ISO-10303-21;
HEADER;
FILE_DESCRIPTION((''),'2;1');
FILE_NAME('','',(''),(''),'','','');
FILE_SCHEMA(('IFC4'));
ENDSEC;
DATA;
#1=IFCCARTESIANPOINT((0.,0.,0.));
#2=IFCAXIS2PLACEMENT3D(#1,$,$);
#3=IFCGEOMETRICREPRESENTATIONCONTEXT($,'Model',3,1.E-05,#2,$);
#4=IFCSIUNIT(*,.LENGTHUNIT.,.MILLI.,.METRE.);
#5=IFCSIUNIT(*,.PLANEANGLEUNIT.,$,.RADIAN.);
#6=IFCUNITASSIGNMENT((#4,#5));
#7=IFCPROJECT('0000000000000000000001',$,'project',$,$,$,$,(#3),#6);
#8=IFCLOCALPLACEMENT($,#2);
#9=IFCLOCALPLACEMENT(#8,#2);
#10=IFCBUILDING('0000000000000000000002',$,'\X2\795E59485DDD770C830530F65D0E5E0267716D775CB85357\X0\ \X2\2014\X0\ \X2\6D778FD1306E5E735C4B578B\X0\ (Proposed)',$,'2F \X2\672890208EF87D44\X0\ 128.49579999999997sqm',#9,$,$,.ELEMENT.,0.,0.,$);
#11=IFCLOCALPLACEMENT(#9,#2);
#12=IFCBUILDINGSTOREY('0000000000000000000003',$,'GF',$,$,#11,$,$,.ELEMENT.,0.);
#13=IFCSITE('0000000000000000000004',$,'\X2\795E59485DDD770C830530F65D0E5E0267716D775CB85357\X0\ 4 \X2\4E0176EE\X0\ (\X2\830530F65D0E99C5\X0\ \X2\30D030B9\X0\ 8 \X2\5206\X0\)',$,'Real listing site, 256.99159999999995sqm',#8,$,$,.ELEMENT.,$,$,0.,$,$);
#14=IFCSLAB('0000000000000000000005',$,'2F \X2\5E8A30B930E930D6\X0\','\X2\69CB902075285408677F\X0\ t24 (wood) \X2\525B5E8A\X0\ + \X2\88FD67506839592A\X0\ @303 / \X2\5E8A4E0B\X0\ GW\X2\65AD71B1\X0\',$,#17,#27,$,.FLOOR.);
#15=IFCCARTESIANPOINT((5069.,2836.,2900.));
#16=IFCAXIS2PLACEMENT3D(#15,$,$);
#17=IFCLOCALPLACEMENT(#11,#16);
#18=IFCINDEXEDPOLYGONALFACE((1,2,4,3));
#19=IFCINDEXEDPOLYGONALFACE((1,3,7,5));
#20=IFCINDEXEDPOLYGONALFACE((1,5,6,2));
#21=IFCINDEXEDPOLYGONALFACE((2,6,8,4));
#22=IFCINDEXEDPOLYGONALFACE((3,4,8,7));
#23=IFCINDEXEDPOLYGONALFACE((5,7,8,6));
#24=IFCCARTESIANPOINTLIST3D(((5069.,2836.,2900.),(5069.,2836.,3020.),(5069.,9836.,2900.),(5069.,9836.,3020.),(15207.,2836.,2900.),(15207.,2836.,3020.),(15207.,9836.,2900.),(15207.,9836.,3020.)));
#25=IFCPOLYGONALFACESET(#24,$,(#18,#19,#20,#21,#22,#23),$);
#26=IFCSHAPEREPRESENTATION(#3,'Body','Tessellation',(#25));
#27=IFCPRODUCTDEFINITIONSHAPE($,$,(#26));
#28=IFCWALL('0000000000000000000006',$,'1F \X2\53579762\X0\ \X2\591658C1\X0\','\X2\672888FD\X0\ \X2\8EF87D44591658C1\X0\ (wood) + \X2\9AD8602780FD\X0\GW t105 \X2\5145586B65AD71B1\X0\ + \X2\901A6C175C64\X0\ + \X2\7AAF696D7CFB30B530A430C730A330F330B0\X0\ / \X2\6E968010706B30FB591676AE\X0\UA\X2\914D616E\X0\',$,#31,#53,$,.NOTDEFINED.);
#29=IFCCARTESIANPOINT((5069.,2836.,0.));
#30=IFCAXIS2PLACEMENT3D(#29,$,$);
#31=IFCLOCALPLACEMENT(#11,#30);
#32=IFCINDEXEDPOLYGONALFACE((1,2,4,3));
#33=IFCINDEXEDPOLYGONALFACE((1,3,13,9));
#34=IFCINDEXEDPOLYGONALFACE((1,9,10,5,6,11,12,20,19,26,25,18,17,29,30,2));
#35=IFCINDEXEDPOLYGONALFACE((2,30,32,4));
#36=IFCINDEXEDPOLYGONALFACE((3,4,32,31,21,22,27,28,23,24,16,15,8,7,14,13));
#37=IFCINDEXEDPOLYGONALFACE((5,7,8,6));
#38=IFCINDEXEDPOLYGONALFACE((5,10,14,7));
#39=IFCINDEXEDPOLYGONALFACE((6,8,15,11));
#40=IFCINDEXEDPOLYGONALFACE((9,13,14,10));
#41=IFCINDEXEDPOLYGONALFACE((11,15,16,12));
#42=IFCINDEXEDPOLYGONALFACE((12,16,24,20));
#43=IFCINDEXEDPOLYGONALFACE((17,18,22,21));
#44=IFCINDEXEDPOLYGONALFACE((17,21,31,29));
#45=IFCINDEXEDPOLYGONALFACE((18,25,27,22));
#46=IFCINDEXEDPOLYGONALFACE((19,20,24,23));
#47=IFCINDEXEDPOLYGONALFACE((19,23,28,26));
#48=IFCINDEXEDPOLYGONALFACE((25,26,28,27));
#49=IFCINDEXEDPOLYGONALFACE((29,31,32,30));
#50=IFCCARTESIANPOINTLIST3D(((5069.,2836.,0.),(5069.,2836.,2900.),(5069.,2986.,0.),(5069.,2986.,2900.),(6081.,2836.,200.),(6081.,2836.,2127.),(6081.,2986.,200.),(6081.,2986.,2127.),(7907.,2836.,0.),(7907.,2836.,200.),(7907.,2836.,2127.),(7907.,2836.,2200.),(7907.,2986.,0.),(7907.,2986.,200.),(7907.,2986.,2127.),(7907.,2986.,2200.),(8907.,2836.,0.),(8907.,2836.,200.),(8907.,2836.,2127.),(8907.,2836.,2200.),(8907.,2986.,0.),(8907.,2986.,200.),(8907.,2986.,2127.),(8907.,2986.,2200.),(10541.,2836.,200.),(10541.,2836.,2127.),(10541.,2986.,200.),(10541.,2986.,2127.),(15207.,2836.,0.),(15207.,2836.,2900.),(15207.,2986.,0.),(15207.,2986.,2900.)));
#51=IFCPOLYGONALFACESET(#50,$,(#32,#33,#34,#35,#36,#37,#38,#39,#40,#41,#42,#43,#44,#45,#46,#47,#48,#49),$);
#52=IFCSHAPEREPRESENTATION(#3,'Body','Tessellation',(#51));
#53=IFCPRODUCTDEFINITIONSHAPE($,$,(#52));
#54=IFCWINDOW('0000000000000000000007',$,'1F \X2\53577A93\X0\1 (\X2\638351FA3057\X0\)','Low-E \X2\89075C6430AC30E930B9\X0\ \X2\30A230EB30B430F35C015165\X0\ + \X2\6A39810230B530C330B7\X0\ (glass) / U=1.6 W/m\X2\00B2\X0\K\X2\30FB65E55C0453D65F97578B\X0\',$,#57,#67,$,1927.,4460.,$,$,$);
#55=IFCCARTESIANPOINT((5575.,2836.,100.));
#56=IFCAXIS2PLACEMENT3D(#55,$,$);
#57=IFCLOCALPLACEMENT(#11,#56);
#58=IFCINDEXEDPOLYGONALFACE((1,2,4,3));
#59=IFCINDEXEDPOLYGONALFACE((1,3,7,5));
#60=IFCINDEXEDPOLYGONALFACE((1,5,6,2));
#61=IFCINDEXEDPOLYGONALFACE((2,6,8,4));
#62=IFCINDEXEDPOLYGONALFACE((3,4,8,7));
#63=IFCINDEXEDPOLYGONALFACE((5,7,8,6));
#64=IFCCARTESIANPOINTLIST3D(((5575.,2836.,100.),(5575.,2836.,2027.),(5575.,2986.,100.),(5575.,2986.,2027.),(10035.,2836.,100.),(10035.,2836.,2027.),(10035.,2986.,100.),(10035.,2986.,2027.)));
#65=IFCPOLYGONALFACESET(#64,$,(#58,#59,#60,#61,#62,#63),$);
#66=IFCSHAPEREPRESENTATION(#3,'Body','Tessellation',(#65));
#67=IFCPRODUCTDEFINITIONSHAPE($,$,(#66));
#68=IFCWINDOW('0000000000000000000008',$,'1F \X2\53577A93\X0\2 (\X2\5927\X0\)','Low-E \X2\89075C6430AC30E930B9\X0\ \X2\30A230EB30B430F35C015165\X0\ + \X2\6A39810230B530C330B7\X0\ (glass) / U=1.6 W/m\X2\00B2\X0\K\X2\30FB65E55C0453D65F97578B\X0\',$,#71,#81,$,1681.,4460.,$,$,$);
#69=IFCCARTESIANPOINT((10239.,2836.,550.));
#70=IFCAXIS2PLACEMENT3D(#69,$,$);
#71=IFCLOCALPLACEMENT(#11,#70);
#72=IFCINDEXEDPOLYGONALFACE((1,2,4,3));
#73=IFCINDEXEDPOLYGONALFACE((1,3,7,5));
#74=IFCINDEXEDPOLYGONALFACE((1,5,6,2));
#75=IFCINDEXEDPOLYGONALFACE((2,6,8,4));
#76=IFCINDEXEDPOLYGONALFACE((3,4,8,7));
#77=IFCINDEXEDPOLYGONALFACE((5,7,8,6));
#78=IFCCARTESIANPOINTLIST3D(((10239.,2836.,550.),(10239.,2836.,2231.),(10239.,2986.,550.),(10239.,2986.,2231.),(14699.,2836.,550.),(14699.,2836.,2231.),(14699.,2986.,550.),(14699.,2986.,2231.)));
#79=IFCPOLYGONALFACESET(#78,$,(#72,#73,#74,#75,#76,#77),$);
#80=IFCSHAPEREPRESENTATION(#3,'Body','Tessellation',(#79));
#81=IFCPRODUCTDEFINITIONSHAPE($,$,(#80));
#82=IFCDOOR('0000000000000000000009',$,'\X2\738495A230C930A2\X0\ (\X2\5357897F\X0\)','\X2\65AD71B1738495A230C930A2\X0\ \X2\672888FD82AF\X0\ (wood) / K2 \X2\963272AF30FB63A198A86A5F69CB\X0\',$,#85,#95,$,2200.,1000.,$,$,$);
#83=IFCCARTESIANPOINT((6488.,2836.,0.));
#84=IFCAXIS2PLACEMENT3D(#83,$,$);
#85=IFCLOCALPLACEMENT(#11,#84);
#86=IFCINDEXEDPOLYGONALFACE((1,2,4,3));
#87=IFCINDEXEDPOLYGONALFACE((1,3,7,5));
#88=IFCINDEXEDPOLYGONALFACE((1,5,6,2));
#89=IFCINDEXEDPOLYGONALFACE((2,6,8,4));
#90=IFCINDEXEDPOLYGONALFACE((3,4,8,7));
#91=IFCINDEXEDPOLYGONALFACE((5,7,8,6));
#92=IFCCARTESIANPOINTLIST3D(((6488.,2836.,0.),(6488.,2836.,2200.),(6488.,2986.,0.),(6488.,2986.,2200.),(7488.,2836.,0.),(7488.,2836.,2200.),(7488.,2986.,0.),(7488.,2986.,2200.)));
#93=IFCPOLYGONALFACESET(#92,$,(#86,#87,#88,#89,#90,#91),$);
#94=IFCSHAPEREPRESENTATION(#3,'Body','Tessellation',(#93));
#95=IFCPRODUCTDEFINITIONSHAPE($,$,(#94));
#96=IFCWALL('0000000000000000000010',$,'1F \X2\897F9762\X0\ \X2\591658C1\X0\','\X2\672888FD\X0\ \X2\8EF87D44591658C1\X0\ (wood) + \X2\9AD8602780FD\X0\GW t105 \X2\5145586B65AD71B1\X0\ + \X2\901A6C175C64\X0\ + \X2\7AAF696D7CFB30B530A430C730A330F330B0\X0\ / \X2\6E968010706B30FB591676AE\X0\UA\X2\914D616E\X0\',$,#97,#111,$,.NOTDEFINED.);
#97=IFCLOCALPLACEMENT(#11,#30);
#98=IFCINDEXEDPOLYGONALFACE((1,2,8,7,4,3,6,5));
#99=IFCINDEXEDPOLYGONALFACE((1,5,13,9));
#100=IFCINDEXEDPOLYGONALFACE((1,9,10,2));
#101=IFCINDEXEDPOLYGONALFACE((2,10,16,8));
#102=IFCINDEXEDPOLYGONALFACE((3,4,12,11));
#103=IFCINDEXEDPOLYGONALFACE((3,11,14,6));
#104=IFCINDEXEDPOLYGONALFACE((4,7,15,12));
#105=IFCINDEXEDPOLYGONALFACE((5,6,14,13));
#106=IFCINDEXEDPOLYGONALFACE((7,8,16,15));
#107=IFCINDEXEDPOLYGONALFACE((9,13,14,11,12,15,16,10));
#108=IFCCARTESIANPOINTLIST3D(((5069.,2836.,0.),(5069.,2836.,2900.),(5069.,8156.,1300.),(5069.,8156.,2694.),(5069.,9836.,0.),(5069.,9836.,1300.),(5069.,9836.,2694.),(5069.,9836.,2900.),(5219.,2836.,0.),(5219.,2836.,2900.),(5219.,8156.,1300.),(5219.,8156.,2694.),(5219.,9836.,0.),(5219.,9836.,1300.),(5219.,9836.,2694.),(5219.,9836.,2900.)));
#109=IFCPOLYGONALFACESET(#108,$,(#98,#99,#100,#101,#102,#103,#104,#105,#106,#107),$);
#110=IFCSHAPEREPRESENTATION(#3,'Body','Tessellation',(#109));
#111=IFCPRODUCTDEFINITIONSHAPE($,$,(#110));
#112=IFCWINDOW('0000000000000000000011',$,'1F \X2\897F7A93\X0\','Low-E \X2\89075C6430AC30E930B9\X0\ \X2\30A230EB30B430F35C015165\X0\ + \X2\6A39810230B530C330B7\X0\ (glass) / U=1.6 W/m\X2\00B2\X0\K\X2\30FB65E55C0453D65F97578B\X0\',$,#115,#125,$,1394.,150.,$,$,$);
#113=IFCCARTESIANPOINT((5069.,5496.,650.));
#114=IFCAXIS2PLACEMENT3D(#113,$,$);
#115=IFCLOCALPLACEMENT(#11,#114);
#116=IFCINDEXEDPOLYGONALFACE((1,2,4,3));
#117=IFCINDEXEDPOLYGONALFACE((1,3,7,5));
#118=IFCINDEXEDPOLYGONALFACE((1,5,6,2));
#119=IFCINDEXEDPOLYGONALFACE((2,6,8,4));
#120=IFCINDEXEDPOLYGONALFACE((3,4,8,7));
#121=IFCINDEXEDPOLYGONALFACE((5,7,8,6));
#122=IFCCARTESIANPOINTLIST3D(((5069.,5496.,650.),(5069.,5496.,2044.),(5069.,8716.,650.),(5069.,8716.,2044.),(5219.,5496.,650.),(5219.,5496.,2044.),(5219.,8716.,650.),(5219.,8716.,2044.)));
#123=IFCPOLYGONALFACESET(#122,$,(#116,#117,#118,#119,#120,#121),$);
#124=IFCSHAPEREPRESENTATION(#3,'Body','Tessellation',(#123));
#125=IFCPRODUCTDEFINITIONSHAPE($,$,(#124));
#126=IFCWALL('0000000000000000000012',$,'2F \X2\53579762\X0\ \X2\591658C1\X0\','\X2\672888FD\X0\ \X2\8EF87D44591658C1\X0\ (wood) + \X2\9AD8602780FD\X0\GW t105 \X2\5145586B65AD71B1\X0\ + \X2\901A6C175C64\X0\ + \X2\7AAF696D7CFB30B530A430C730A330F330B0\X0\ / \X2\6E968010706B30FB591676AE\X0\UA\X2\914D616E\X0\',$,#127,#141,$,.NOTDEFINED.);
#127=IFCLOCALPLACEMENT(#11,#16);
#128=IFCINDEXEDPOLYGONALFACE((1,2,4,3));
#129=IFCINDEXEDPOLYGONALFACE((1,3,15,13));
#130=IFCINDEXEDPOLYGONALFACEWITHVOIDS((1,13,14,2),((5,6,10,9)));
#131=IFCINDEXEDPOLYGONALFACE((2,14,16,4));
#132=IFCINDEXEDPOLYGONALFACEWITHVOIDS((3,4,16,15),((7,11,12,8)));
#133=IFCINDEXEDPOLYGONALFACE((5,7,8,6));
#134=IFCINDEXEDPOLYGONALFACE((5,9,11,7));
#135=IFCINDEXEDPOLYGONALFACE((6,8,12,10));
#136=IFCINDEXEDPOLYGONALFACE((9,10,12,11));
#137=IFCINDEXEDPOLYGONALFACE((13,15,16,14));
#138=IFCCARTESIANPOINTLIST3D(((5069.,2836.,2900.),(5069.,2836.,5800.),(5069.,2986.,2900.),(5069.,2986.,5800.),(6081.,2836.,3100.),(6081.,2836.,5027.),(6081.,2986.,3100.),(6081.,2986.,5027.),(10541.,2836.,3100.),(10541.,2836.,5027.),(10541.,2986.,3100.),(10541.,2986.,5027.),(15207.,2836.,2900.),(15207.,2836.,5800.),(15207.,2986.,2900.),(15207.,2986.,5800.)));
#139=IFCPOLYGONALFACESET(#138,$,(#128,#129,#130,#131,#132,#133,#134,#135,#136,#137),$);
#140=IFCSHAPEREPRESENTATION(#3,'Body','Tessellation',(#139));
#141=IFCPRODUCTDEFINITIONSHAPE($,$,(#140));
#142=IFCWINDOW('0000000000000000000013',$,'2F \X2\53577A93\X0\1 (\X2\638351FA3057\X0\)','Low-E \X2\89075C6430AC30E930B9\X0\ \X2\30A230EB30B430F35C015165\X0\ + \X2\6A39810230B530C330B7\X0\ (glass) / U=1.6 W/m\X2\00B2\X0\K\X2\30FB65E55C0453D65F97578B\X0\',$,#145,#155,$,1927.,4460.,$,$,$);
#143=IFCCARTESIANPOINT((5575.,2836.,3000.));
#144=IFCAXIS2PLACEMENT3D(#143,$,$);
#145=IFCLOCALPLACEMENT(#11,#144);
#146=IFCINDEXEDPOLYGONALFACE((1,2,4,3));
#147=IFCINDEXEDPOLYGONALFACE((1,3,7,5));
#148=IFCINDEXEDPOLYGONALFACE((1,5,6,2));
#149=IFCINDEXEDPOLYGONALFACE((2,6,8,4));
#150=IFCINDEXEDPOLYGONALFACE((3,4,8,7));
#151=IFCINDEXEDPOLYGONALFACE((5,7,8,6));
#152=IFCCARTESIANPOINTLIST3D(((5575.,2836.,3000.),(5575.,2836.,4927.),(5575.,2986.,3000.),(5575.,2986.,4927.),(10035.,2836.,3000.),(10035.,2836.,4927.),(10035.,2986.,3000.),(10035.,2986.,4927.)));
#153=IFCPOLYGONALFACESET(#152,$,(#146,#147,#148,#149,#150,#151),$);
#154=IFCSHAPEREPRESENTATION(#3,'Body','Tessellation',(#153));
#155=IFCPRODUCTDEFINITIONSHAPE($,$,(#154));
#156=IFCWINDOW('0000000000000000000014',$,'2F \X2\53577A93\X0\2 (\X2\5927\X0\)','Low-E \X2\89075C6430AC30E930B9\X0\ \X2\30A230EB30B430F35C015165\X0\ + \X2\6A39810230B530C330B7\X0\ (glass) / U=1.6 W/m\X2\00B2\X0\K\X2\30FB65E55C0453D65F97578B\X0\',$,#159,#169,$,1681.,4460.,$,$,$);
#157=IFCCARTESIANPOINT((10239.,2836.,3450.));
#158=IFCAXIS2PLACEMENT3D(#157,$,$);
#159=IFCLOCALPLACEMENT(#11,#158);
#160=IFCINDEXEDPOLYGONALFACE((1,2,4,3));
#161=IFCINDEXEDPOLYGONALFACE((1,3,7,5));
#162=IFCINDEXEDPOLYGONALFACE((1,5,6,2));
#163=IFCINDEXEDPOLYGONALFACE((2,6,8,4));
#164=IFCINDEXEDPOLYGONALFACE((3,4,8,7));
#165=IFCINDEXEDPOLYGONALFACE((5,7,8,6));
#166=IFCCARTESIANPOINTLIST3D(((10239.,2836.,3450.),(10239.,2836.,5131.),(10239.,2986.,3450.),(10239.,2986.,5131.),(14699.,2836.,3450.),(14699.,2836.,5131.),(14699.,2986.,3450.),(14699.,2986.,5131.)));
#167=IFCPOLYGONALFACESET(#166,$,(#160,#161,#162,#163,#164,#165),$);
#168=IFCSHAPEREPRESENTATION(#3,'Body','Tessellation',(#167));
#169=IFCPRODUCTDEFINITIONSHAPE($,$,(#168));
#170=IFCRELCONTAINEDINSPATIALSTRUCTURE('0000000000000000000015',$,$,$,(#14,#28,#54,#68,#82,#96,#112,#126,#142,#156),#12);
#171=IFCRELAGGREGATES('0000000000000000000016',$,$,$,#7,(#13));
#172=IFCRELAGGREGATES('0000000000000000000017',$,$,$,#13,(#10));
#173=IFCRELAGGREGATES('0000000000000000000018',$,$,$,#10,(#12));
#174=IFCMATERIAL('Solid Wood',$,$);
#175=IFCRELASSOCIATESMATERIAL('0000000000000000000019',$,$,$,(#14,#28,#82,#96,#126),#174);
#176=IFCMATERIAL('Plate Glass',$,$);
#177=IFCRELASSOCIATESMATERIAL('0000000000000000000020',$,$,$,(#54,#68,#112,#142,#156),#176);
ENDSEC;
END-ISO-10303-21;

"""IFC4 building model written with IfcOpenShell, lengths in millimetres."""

from ifc_helpers import new_model, si_unit, frame, frame_2d, origin, place, context, project, spatial, rectangle, extrude, material, element, fill, save


model = new_model("IFC4")

# Units and contexts
model_context = context("Model", 3, precision=1e-05, world=origin())
ifc_project = project(units=[si_unit("LENGTHUNIT", "METRE", prefix="MILLI"), si_unit("PLANEANGLEUNIT", "RADIAN")], contexts=[model_context])

# Site, building, storey
site_placement = place(None, origin())
site = spatial("IfcSite", under=ifc_project, at=site_placement, Name="神奈川県茅ヶ崎市東海岸南 4 丁目 (茅ヶ崎駅 バス 8 分)", ObjectType="Real listing site, 256.99159999999995sqm", CompositionType="ELEMENT", RefElevation=0.0)
building_placement = place(site_placement, origin())
building = spatial("IfcBuilding", under=site, at=building_placement, Name="神奈川県茅ヶ崎市東海岸南 — 海近の平屋型 (Proposed)", ObjectType="2F 木造軸組 128.49579999999997sqm", CompositionType="ELEMENT", ElevationOfRefHeight=0.0, ElevationOfTerrain=0.0)
storey_placement = place(building_placement, origin())
storey = spatial("IfcBuildingStorey", under=building, at=storey_placement, Name="GF", CompositionType="ELEMENT", Elevation=0.0)

# Slab
ifc_material_1 = material(Name="Solid Wood")
slab_1_placement = place(storey_placement, frame((5069.0, 2836.0, 2900.0)))
element("IfcSlab", 1, at=slab_1_placement, inside=storey, material=ifc_material_1, Name="2F 床スラブ", Description="構造用合板 t24 (wood) 剛床 + 製材根太 @303 / 床下 GW断熱", PredefinedType="FLOOR", context=model_context, shape_type="SweptSolid", body=[
    extrude(rectangle(XDim=10138.0, YDim=7000.0, at=frame_2d((5069.0, 3500.0))), frame((5069.0, 2836.0, 2900.0)), (0.0, 0.0, 1.0), 120.0),
])

# Wall, openings, windows, door
wall_1_placement = place(storey_placement, frame((5069.0, 2836.0, 0.0)))
wall_1 = element("IfcWall", 2, at=wall_1_placement, inside=storey, material=ifc_material_1, Name="1F 南面 外壁", Description="木製 軸組外壁 (wood) + 高性能GW t105 充填断熱 + 通気層 + 窯業系サイディング / 準耐火・外皮UA配慮", PredefinedType="NOTDEFINED", context=model_context, shape_type="SweptSolid", body=[
    extrude(rectangle(XDim=10138.0, YDim=150.0, at=frame_2d((5069.0, 75.0))), frame((5069.0, 2836.0, 0.0)), (0.0, 0.0, 1.0), 2900.0),
])
opening_1_placement = place(storey_placement, frame((5575.0, 2836.0, 100.0)))
opening_1 = element("IfcOpeningElement", 3, at=opening_1_placement, cuts=wall_1, PredefinedType="NOTDEFINED", context=model_context, shape_type="SweptSolid", body=[
    extrude(rectangle(XDim=4460.0, YDim=150.0, at=frame_2d((2230.0, 75.0))), frame((5575.0, 2836.0, 100.0)), (0.0, 0.0, 1.0), 1927.0),
])
opening_2_placement = place(storey_placement, frame((10239.0, 2836.0, 550.0)))
opening_2 = element("IfcOpeningElement", 4, at=opening_2_placement, cuts=wall_1, PredefinedType="NOTDEFINED", context=model_context, shape_type="SweptSolid", body=[
    extrude(rectangle(XDim=4460.0, YDim=150.0, at=frame_2d((2230.0, 75.0))), frame((10239.0, 2836.0, 550.0)), (0.0, 0.0, 1.0), 1681.0),
])
opening_3_placement = place(storey_placement, frame((6488.0, 2836.0, 0.0)))
opening_3 = element("IfcOpeningElement", 5, at=opening_3_placement, cuts=wall_1, PredefinedType="NOTDEFINED", context=model_context, shape_type="SweptSolid", body=[
    extrude(rectangle(XDim=1000.0, YDim=150.0, at=frame_2d((500.0, 75.0))), frame((6488.0, 2836.0, 0.0)), (0.0, 0.0, 1.0), 2200.0),
])
ifc_material_2 = material(Name="Plate Glass")
window_1_placement = place(storey_placement, frame((5575.0, 2836.0, 100.0)))
window_1 = element("IfcWindow", 6, at=window_1_placement, inside=storey, material=ifc_material_2, Name="1F 南窓1 (掃出し)", Description="Low-E 複層ガラス アルゴン封入 + 樹脂サッシ (glass) / U=1.6 W/m²K・日射取得型", OverallHeight=1927.0, OverallWidth=4460.0, context=model_context, shape_type="SweptSolid", body=[
    extrude(rectangle(XDim=4460.0, YDim=150.0, at=frame_2d((2230.0, 75.0))), frame((5575.0, 2836.0, 100.0)), (0.0, 0.0, 1.0), 1927.0),
])
fill(opening_1, window_1)
window_2_placement = place(storey_placement, frame((10239.0, 2836.0, 550.0)))
window_2 = element("IfcWindow", 7, at=window_2_placement, inside=storey, material=ifc_material_2, Name="1F 南窓2 (大)", Description="Low-E 複層ガラス アルゴン封入 + 樹脂サッシ (glass) / U=1.6 W/m²K・日射取得型", OverallHeight=1681.0, OverallWidth=4460.0, context=model_context, shape_type="SweptSolid", body=[
    extrude(rectangle(XDim=4460.0, YDim=150.0, at=frame_2d((2230.0, 75.0))), frame((10239.0, 2836.0, 550.0)), (0.0, 0.0, 1.0), 1681.0),
])
fill(opening_2, window_2)
door_placement = place(storey_placement, frame((6488.0, 2836.0, 0.0)))
door = element("IfcDoor", 8, at=door_placement, inside=storey, material=ifc_material_1, Name="玄関ドア (南西)", Description="断熱玄関ドア 木製芯 (wood) / K2 防犯・採風機構", OverallHeight=2200.0, OverallWidth=1000.0, context=model_context, shape_type="SweptSolid", body=[
    extrude(rectangle(XDim=1000.0, YDim=150.0, at=frame_2d((500.0, 75.0))), frame((6488.0, 2836.0, 0.0)), (0.0, 0.0, 1.0), 2200.0),
])
fill(opening_3, door)

# Wall, opening, window
wall_2_placement = place(storey_placement, frame((5069.0, 2836.0, 0.0)))
wall_2 = element("IfcWall", 9, at=wall_2_placement, inside=storey, material=ifc_material_1, Name="1F 西面 外壁", Description="木製 軸組外壁 (wood) + 高性能GW t105 充填断熱 + 通気層 + 窯業系サイディング / 準耐火・外皮UA配慮", PredefinedType="NOTDEFINED", context=model_context, shape_type="SweptSolid", body=[
    extrude(rectangle(XDim=150.0, YDim=7000.0, at=frame_2d((75.0, 3500.0))), frame((5069.0, 2836.0, 0.0)), (0.0, 0.0, 1.0), 2900.0),
])
opening_4_placement = place(storey_placement, frame((5069.0, 5496.0, 650.0)))
opening_4 = element("IfcOpeningElement", 10, at=opening_4_placement, cuts=wall_2, PredefinedType="NOTDEFINED", context=model_context, shape_type="SweptSolid", body=[
    extrude(rectangle(XDim=150.0, YDim=3220.0, at=frame_2d((75.0, 1610.0))), frame((5069.0, 5496.0, 650.0)), (0.0, 0.0, 1.0), 1394.0),
])
window_3_placement = place(storey_placement, frame((5069.0, 5496.0, 650.0)))
window_3 = element("IfcWindow", 11, at=window_3_placement, inside=storey, material=ifc_material_2, Name="1F 西窓", Description="Low-E 複層ガラス アルゴン封入 + 樹脂サッシ (glass) / U=1.6 W/m²K・日射取得型", OverallHeight=1394.0, OverallWidth=150.0, context=model_context, shape_type="SweptSolid", body=[
    extrude(rectangle(XDim=150.0, YDim=3220.0, at=frame_2d((75.0, 1610.0))), frame((5069.0, 5496.0, 650.0)), (0.0, 0.0, 1.0), 1394.0),
])
fill(opening_4, window_3)

# Wall, openings, windows
wall_3_placement = place(storey_placement, frame((5069.0, 2836.0, 2900.0)))
wall_3 = element("IfcWall", 12, at=wall_3_placement, inside=storey, material=ifc_material_1, Name="2F 南面 外壁", Description="木製 軸組外壁 (wood) + 高性能GW t105 充填断熱 + 通気層 + 窯業系サイディング / 準耐火・外皮UA配慮", PredefinedType="NOTDEFINED", context=model_context, shape_type="SweptSolid", body=[
    extrude(rectangle(XDim=10138.0, YDim=150.0, at=frame_2d((5069.0, 75.0))), frame((5069.0, 2836.0, 2900.0)), (0.0, 0.0, 1.0), 2900.0),
])
opening_5_placement = place(storey_placement, frame((5575.0, 2836.0, 3000.0)))
opening_5 = element("IfcOpeningElement", 13, at=opening_5_placement, cuts=wall_3, PredefinedType="NOTDEFINED", context=model_context, shape_type="SweptSolid", body=[
    extrude(rectangle(XDim=4460.0, YDim=150.0, at=frame_2d((2230.0, 75.0))), frame((5575.0, 2836.0, 3000.0)), (0.0, 0.0, 1.0), 1927.0),
])
opening_6_placement = place(storey_placement, frame((10239.0, 2836.0, 3450.0)))
opening_6 = element("IfcOpeningElement", 14, at=opening_6_placement, cuts=wall_3, PredefinedType="NOTDEFINED", context=model_context, shape_type="SweptSolid", body=[
    extrude(rectangle(XDim=4460.0, YDim=150.0, at=frame_2d((2230.0, 75.0))), frame((10239.0, 2836.0, 3450.0)), (0.0, 0.0, 1.0), 1681.0),
])
window_4_placement = place(storey_placement, frame((5575.0, 2836.0, 3000.0)))
window_4 = element("IfcWindow", 15, at=window_4_placement, inside=storey, material=ifc_material_2, Name="2F 南窓1 (掃出し)", Description="Low-E 複層ガラス アルゴン封入 + 樹脂サッシ (glass) / U=1.6 W/m²K・日射取得型", OverallHeight=1927.0, OverallWidth=4460.0, context=model_context, shape_type="SweptSolid", body=[
    extrude(rectangle(XDim=4460.0, YDim=150.0, at=frame_2d((2230.0, 75.0))), frame((5575.0, 2836.0, 3000.0)), (0.0, 0.0, 1.0), 1927.0),
])
fill(opening_5, window_4)
window_5_placement = place(storey_placement, frame((10239.0, 2836.0, 3450.0)))
window_5 = element("IfcWindow", 16, at=window_5_placement, inside=storey, material=ifc_material_2, Name="2F 南窓2 (大)", Description="Low-E 複層ガラス アルゴン封入 + 樹脂サッシ (glass) / U=1.6 W/m²K・日射取得型", OverallHeight=1681.0, OverallWidth=4460.0, context=model_context, shape_type="SweptSolid", body=[
    extrude(rectangle(XDim=4460.0, YDim=150.0, at=frame_2d((2230.0, 75.0))), frame((10239.0, 2836.0, 3450.0)), (0.0, 0.0, 1.0), 1681.0),
])
fill(opening_6, window_5)

save(model, "model.ifc")
